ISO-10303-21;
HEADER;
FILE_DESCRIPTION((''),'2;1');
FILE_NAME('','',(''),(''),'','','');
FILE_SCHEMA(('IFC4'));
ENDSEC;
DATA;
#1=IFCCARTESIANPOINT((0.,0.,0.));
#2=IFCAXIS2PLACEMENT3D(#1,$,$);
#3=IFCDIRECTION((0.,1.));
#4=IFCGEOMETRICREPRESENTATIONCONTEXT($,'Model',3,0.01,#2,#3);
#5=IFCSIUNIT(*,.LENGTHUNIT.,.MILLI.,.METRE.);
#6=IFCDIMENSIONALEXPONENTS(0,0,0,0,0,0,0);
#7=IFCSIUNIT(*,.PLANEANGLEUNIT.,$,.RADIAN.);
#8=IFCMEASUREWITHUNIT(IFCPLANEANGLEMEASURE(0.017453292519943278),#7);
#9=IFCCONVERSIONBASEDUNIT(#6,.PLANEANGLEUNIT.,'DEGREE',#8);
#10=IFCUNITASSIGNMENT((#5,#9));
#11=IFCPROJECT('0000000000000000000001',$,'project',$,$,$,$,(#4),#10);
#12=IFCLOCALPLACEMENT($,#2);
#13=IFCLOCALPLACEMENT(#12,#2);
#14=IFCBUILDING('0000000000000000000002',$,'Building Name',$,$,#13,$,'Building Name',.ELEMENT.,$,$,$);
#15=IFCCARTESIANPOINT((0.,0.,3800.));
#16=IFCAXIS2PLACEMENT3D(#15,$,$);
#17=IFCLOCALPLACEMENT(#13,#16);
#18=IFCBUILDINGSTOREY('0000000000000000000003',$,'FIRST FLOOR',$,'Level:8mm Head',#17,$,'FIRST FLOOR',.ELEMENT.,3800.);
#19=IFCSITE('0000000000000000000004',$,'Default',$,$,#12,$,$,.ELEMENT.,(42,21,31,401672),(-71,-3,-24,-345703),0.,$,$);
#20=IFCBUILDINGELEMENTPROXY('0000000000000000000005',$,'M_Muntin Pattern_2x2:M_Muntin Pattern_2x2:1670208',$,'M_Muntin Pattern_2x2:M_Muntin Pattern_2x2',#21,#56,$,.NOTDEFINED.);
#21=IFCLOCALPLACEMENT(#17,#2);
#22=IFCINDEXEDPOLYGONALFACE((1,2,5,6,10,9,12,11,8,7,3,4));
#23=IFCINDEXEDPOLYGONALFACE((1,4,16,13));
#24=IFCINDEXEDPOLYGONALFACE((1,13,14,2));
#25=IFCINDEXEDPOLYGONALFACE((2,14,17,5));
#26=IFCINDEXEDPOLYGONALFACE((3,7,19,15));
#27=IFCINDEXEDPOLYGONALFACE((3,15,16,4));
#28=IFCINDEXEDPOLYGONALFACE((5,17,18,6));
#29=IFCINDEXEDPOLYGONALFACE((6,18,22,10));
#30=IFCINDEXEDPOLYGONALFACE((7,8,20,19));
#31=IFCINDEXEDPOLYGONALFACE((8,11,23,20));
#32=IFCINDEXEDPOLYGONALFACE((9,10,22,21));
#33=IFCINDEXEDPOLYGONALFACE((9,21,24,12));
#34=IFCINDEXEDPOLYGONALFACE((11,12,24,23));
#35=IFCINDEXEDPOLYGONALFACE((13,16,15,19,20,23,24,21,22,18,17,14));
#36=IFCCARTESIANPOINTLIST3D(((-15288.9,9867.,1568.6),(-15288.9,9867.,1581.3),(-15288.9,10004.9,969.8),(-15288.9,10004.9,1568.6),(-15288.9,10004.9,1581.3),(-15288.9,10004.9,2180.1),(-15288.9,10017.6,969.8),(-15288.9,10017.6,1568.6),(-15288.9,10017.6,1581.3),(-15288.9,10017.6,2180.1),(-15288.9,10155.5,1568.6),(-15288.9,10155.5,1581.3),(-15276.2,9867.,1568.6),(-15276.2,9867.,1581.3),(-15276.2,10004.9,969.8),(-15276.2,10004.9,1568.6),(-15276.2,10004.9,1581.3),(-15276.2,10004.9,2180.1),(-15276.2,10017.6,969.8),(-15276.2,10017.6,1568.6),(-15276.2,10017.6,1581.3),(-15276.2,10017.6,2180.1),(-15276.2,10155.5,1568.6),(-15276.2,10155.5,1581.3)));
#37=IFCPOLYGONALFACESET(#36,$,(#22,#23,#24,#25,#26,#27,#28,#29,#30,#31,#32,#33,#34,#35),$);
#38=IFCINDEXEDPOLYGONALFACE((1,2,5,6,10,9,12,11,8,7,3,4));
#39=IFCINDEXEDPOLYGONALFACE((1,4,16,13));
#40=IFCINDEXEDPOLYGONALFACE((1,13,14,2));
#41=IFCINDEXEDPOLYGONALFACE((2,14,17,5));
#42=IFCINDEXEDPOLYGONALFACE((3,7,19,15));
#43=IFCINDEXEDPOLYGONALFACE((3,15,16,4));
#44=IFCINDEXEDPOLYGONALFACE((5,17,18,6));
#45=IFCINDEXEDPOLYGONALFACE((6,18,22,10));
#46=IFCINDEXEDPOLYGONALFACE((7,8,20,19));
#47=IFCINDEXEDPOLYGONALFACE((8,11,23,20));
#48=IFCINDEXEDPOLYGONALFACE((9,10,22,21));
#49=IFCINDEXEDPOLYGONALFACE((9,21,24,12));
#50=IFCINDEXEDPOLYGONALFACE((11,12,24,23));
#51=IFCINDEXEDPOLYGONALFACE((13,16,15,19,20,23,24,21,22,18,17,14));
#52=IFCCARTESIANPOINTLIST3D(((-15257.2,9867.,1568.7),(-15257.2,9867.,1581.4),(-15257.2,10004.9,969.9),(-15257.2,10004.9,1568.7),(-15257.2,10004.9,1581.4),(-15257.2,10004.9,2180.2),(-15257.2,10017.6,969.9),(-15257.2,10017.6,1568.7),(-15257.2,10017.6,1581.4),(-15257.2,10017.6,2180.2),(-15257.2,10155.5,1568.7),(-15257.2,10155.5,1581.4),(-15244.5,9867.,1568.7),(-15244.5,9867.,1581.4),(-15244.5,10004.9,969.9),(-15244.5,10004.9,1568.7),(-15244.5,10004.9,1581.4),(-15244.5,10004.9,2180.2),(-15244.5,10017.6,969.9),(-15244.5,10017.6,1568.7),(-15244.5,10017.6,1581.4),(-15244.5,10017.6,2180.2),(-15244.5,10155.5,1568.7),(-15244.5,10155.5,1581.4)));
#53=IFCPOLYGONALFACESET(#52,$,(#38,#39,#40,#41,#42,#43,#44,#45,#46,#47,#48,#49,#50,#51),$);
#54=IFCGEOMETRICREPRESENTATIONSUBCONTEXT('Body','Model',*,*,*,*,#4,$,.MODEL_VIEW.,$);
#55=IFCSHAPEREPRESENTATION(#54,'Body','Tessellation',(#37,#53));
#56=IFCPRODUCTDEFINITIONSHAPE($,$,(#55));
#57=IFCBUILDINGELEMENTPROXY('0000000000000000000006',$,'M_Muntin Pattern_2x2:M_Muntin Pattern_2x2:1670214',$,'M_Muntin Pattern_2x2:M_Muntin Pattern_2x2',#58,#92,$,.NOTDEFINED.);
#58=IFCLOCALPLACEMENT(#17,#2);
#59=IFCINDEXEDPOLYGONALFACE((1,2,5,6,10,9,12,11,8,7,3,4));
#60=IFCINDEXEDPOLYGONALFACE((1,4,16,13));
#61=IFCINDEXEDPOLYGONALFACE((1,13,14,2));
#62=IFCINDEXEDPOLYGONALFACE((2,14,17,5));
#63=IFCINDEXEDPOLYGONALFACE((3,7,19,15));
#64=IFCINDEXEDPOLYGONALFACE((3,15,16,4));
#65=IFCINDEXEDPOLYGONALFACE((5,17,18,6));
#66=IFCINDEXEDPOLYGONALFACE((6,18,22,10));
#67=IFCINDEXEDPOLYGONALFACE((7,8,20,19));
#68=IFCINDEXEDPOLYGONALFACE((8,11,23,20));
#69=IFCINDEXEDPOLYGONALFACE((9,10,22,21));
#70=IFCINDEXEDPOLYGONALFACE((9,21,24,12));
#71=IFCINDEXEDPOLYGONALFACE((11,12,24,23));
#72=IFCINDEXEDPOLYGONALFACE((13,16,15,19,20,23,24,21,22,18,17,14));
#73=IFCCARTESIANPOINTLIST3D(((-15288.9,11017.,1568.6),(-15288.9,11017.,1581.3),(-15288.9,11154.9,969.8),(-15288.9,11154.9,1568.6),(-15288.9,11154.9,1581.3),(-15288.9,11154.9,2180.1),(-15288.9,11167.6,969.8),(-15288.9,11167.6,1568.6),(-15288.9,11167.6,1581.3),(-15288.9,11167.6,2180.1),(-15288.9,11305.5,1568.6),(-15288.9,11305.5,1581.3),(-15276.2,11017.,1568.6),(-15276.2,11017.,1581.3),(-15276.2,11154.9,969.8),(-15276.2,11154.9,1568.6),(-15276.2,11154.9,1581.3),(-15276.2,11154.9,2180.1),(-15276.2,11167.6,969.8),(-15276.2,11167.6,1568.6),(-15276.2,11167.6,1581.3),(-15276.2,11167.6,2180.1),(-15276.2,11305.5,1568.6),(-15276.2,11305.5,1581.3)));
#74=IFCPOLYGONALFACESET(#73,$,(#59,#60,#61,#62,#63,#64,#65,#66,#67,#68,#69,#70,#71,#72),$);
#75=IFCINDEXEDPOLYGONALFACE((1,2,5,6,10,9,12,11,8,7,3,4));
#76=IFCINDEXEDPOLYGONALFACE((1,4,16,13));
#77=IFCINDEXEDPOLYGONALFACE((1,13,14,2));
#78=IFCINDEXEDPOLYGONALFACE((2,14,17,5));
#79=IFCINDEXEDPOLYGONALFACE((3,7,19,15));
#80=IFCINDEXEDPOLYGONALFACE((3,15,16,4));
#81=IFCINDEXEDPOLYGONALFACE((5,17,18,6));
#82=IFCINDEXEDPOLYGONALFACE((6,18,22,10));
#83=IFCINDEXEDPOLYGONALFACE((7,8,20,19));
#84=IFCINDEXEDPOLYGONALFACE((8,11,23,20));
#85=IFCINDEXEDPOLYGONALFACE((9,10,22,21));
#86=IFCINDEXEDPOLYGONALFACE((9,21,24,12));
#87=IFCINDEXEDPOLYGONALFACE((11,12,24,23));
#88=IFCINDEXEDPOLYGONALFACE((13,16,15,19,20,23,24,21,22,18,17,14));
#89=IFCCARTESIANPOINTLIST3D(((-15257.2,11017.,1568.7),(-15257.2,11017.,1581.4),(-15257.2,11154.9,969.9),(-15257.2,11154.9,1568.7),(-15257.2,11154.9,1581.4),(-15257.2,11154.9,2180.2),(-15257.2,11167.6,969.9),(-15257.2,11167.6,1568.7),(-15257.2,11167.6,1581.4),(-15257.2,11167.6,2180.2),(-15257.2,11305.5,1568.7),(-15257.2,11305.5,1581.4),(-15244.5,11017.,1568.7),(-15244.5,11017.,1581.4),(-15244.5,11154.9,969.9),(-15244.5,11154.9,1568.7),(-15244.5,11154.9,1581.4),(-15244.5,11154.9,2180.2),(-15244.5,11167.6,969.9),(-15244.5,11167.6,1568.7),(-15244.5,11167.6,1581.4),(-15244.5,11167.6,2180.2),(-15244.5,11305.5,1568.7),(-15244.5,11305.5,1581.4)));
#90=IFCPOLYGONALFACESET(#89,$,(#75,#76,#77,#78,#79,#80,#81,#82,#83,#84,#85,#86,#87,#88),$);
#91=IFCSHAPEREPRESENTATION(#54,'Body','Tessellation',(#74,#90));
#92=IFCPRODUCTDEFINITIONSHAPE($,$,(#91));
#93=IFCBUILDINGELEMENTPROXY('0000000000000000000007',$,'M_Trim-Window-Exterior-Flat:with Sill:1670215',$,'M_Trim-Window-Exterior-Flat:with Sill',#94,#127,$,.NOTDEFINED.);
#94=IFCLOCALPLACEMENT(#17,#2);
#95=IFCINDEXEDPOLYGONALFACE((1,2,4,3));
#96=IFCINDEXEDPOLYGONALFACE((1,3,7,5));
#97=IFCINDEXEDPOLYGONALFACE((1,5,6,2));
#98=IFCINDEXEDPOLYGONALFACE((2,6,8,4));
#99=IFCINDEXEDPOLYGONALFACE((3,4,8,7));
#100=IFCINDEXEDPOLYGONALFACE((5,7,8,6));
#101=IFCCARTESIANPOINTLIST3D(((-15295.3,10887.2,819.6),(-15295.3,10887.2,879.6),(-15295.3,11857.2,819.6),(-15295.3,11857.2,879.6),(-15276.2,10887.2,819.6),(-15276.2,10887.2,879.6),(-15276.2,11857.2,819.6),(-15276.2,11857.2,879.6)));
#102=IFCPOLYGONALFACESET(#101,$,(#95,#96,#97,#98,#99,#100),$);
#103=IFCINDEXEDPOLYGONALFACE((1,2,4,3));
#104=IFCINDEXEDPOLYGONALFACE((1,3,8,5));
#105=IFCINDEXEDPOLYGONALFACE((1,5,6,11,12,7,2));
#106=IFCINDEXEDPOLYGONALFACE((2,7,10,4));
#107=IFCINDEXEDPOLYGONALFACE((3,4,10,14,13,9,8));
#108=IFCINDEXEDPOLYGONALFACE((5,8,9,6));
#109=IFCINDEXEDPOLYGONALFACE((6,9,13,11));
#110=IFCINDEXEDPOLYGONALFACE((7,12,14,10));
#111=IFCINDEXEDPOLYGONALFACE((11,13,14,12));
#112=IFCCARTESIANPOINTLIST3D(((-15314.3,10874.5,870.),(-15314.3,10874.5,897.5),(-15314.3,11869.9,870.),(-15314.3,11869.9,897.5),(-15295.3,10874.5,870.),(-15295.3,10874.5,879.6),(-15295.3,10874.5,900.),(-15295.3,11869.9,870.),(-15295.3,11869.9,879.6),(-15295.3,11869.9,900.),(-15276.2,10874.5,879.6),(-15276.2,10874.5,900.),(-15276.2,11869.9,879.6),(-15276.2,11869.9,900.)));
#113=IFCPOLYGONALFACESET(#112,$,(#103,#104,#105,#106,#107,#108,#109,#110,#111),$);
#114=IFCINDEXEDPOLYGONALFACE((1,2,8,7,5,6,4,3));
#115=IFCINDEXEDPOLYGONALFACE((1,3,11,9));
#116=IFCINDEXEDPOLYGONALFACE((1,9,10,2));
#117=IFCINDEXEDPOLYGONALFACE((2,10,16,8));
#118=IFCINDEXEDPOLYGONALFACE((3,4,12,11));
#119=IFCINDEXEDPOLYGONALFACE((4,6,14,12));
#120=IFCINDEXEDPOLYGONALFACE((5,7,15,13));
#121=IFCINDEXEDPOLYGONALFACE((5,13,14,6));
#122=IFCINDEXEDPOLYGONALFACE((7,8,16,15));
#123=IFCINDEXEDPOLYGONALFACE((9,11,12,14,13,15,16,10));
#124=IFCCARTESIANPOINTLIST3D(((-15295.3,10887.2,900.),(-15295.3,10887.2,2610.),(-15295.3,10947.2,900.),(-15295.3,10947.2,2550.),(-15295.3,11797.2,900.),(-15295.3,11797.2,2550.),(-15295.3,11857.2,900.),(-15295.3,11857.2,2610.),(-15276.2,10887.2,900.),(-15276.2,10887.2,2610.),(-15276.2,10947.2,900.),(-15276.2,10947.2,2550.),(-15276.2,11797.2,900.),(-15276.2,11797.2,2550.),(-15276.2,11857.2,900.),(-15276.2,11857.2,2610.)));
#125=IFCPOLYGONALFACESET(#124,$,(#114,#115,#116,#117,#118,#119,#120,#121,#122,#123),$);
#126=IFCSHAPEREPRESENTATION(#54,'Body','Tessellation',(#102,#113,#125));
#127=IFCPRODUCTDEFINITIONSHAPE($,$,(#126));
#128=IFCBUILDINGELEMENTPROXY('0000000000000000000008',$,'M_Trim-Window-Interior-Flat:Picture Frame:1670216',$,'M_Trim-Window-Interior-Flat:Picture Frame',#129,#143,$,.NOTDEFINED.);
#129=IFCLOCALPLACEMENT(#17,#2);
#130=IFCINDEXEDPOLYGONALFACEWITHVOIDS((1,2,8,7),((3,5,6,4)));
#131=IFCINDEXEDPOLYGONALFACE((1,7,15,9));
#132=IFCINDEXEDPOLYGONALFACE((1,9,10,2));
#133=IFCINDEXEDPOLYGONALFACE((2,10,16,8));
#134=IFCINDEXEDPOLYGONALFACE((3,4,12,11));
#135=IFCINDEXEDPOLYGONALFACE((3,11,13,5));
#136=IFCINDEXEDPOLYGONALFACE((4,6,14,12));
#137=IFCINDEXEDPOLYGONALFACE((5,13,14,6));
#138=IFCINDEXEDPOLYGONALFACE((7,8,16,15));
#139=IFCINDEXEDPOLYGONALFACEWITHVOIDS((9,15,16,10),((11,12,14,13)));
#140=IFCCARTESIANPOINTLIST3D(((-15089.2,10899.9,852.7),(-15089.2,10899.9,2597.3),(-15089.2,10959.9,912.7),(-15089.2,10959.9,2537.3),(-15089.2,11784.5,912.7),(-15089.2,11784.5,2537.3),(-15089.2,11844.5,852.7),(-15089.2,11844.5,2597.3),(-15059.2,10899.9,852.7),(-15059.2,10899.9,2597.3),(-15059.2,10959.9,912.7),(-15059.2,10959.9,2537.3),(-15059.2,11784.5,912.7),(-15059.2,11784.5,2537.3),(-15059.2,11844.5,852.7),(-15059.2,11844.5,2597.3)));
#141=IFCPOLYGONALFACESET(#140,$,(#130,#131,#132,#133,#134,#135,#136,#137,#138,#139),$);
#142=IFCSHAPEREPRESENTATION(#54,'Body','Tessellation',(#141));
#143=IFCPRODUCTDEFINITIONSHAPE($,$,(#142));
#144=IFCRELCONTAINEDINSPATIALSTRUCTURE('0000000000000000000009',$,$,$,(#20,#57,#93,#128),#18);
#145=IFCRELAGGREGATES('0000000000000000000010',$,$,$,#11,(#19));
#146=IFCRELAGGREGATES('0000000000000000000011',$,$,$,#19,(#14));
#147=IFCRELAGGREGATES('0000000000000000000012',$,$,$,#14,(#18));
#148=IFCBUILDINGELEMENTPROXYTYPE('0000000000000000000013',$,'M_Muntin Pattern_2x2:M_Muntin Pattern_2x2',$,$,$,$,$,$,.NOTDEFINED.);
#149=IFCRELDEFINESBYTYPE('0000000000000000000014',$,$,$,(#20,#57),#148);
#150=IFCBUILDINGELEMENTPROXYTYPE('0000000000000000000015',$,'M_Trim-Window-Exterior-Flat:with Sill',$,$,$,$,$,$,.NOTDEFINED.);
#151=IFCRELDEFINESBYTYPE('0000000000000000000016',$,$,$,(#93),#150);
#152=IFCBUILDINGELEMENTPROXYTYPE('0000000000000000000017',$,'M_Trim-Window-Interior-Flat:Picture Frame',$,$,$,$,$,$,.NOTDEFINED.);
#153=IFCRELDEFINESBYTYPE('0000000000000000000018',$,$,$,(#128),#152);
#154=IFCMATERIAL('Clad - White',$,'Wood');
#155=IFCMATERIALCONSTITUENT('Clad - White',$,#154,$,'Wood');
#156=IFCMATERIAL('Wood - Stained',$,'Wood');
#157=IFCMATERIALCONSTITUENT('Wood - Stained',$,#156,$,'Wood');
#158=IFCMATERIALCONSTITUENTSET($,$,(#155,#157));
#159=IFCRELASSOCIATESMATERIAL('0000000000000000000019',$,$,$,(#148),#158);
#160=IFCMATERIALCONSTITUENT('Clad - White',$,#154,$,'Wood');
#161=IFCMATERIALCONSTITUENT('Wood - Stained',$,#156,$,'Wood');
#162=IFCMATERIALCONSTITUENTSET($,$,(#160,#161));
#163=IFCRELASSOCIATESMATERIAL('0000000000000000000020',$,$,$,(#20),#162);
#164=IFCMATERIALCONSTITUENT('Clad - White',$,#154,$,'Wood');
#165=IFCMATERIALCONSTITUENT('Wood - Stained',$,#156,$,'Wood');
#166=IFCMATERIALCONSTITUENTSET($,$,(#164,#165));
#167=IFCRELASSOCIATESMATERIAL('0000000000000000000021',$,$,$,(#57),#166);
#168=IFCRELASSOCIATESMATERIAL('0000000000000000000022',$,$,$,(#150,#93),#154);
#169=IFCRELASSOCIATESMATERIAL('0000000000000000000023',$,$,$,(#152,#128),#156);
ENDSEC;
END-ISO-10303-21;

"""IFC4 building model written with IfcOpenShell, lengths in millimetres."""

from ifc_helpers import new_model, entity, si_unit, converted_unit, direction, frame, origin, place, context, subcontext, project, spatial, indexed_curve, outline, extrude, source, transform, mapped, material, constituent, constituent_set, type_object, type_shapes, element, save


model = new_model("IFC4")

# Units and contexts
model_context = context("Model", 3, precision=0.01, world=origin(), true_north=direction((0.0, 1.0)))
body_context = subcontext(model_context, "Body", "Model", "MODEL_VIEW")
ifc_project = project(units=[si_unit("LENGTHUNIT", "METRE", prefix="MILLI"), converted_unit("PLANEANGLEUNIT", "DEGREE", entity("IfcPlaneAngleMeasure", 0.017453292519943278), si_unit("PLANEANGLEUNIT", "RADIAN"), dimensions=[0, 0, 0, 0, 0, 0, 0])], contexts=[model_context])

# Site, building, storey
site_placement = place(None, origin())
site = spatial("IfcSite", under=ifc_project, at=site_placement, Name="Default", CompositionType="ELEMENT", RefLatitude=(42, 21, 31, 401672), RefLongitude=(-71, -3, -24, -345703), RefElevation=0.0)
building_placement = place(site_placement, origin())
building = spatial("IfcBuilding", under=site, at=building_placement, Name="Building Name", LongName="Building Name", CompositionType="ELEMENT")
storey_placement = place(building_placement, frame((0.0, 0.0, 3800.0)))
storey = spatial("IfcBuildingStorey", under=building, at=storey_placement, Name="FIRST FLOOR", ObjectType="Level:8mm Head", LongName="FIRST FLOOR", CompositionType="ELEMENT", Elevation=3800.0)

# Shared definitions
ifc_material_1 = material(Name="Wood - Stained", Category="Wood")

# Building element proxies
ifc_material_2 = material(Name="Clad - White", Category="Wood")
ifc_constituent_1 = constituent(ifc_material_2, Name="Clad - White", Category="Wood")
ifc_constituent_2 = constituent(ifc_material_1, Name="Wood - Stained", Category="Wood")
ifc_constituent_set_1 = constituent_set(constituents=[ifc_constituent_1, ifc_constituent_2])
ifc_constituent_3 = constituent(ifc_material_2, Name="Clad - White", Category="Wood")
ifc_constituent_4 = constituent(ifc_material_1, Name="Wood - Stained", Category="Wood")
ifc_constituent_set_2 = constituent_set(constituents=[ifc_constituent_3, ifc_constituent_4])
building_element_proxy_type_1 = type_object("IfcBuildingElementProxyType", Name="M_Muntin Pattern_2x2:M_Muntin Pattern_2x2", PredefinedType="NOTDEFINED", material=ifc_constituent_set_2)
shared_shape_1 = source(origin(), body_context, "Body", "SweptSolid", [
    extrude(outline(indexed_curve([(6.4, -6.4), (605.1, -6.4), (605.1, 6.3), (6.4, 6.3), (6.4, 144.2), (-6.3, 144.2), (-6.3, 6.3), (-605.2, 6.3), (-605.2, -6.4), (-6.3, -6.4), (-6.3, -144.2), (6.4, -144.2), (6.4, -6.4)], self_intersect=False)), frame((0.0, 9.5, 605.1), z_axis=(0.0, 1.0, 0.0), x_axis=(0.0, 0.0, 1.0)), (0.0, 0.0, 1.0), 12.7),
    extrude(outline(indexed_curve([(6.4, -6.4), (605.2, -6.4), (605.2, 6.3), (6.4, 6.3), (6.4, 144.2), (-6.3, 144.2), (-6.3, 6.3), (-605.2, 6.3), (-605.2, -6.4), (-6.3, -6.4), (-6.3, -144.2), (6.4, -144.2), (6.4, -6.4)], self_intersect=False)), frame((0.0, -22.2, 605.2), z_axis=(0.0, 1.0, 0.0), x_axis=(0.0, 0.0, 1.0)), (0.0, 0.0, 1.0), 12.7),
])
type_shapes(building_element_proxy_type_1, [shared_shape_1])
proxy_1_placement = place(storey_placement, frame((-15266.7, 10011.3, 969.9), z_axis=(0.0, 0.0, 1.0), x_axis=(0.0, 1.0, 0.0)))
element("IfcBuildingElementProxy", 1, at=proxy_1_placement, inside=storey, type_object=building_element_proxy_type_1, material=ifc_constituent_set_1, Name="M_Muntin Pattern_2x2:M_Muntin Pattern_2x2:1670208", ObjectType="M_Muntin Pattern_2x2:M_Muntin Pattern_2x2", PredefinedType="NOTDEFINED", context=body_context, shape_type="MappedRepresentation", body=[
    mapped(shared_shape_1, transform((0.0, 0.0, 0.0), scale=1.0)),
])
ifc_constituent_5 = constituent(ifc_material_2, Name="Clad - White", Category="Wood")
ifc_constituent_6 = constituent(ifc_material_1, Name="Wood - Stained", Category="Wood")
ifc_constituent_set_3 = constituent_set(constituents=[ifc_constituent_5, ifc_constituent_6])
proxy_2_placement = place(storey_placement, frame((-15266.7, 11161.3, 969.9), z_axis=(0.0, 0.0, 1.0), x_axis=(0.0, 1.0, 0.0)))
element("IfcBuildingElementProxy", 2, at=proxy_2_placement, inside=storey, type_object=building_element_proxy_type_1, material=ifc_constituent_set_3, Name="M_Muntin Pattern_2x2:M_Muntin Pattern_2x2:1670214", ObjectType="M_Muntin Pattern_2x2:M_Muntin Pattern_2x2", PredefinedType="NOTDEFINED", context=body_context, shape_type="MappedRepresentation", body=[
    mapped(shared_shape_1, transform((0.0, 0.0, 0.0), scale=1.0)),
])
building_element_proxy_type_2 = type_object("IfcBuildingElementProxyType", Name="M_Trim-Window-Exterior-Flat:with Sill", PredefinedType="NOTDEFINED", material=ifc_material_2)
shared_shape_2 = source(origin(), body_context, "Body", "SweptSolid", [
    extrude(outline(indexed_curve([(-30.0, -485.0), (30.0, -485.0), (30.0, 485.0), (-30.0, 485.0), (-30.0, -485.0)], self_intersect=False)), frame((0.0, 1700.4, 0.0), z_axis=(0.0, 0.0, 1.0), x_axis=(0.0, 1.0, 0.0)), (0.0, 0.0, 1.0), 19.0),
    extrude(outline(indexed_curve([(-15.2, -19.0), (12.3, -19.0), (14.8, 0.0), (14.8, 19.0), (-5.7, 19.0), (-5.7, 0.0), (-15.2, 0.0), (-15.2, -19.0)], self_intersect=False)), frame((-497.7, 1664.8, 19.0), z_axis=(1.0, 0.0, 0.0), x_axis=(0.0, -1.0, 0.0)), (0.0, 0.0, 1.0), 995.4),
    extrude(outline(indexed_curve([(-485.0, -870.0), (485.0, -870.0), (485.0, 840.0), (425.0, 840.0), (425.0, -810.0), (-425.0, -810.0), (-425.0, 840.0), (-485.0, 840.0), (-485.0, -870.0)], self_intersect=False)), frame((0.0, 810.0, 0.0)), (0.0, 0.0, 1.0), 19.0),
])
type_shapes(building_element_proxy_type_2, [shared_shape_2])
proxy_3_placement = place(storey_placement, frame((-15276.2, 11372.2, 2550.0), z_axis=(-1.0, 0.0, 0.0), x_axis=(0.0, 1.0, 0.0)))
element("IfcBuildingElementProxy", 3, at=proxy_3_placement, inside=storey, type_object=building_element_proxy_type_2, material=ifc_material_2, Name="M_Trim-Window-Exterior-Flat:with Sill:1670215", ObjectType="M_Trim-Window-Exterior-Flat:with Sill", PredefinedType="NOTDEFINED", context=body_context, shape_type="MappedRepresentation", body=[
    mapped(shared_shape_2, transform((0.0, 0.0, 0.0), scale=1.0)),
])
building_element_proxy_type_3 = type_object("IfcBuildingElementProxyType", Name="M_Trim-Window-Interior-Flat:Picture Frame", PredefinedType="NOTDEFINED", material=ifc_material_1)
shared_shape_3 = source(origin(), body_context, "Body", "SweptSolid", [
    extrude(outline(indexed_curve([(-872.3, -472.3), (872.3, -472.3), (872.3, 472.3), (-872.3, 472.3), (-872.3, -472.3)], self_intersect=False), holes=[indexed_curve([(-812.3, -412.3), (-812.3, 412.3), (812.3, 412.3), (812.3, -412.3), (-812.3, -412.3)], self_intersect=False)]), frame((0.0, 825.0, 0.0), z_axis=(0.0, 0.0, 1.0), x_axis=(0.0, 1.0, 0.0)), (0.0, 0.0, 1.0), 30.0),
])
type_shapes(building_element_proxy_type_3, [shared_shape_3])
proxy_4_placement = place(storey_placement, frame((-15089.2, 11372.2, 2550.0), z_axis=(1.0, 0.0, 0.0), x_axis=(0.0, -1.0, 0.0)))
element("IfcBuildingElementProxy", 4, at=proxy_4_placement, inside=storey, type_object=building_element_proxy_type_3, material=ifc_material_1, Name="M_Trim-Window-Interior-Flat:Picture Frame:1670216", ObjectType="M_Trim-Window-Interior-Flat:Picture Frame", PredefinedType="NOTDEFINED", context=body_context, shape_type="MappedRepresentation", body=[
    mapped(shared_shape_3, transform((0.0, 0.0, 0.0), scale=1.0)),
])

save(model, "model.ifc")
